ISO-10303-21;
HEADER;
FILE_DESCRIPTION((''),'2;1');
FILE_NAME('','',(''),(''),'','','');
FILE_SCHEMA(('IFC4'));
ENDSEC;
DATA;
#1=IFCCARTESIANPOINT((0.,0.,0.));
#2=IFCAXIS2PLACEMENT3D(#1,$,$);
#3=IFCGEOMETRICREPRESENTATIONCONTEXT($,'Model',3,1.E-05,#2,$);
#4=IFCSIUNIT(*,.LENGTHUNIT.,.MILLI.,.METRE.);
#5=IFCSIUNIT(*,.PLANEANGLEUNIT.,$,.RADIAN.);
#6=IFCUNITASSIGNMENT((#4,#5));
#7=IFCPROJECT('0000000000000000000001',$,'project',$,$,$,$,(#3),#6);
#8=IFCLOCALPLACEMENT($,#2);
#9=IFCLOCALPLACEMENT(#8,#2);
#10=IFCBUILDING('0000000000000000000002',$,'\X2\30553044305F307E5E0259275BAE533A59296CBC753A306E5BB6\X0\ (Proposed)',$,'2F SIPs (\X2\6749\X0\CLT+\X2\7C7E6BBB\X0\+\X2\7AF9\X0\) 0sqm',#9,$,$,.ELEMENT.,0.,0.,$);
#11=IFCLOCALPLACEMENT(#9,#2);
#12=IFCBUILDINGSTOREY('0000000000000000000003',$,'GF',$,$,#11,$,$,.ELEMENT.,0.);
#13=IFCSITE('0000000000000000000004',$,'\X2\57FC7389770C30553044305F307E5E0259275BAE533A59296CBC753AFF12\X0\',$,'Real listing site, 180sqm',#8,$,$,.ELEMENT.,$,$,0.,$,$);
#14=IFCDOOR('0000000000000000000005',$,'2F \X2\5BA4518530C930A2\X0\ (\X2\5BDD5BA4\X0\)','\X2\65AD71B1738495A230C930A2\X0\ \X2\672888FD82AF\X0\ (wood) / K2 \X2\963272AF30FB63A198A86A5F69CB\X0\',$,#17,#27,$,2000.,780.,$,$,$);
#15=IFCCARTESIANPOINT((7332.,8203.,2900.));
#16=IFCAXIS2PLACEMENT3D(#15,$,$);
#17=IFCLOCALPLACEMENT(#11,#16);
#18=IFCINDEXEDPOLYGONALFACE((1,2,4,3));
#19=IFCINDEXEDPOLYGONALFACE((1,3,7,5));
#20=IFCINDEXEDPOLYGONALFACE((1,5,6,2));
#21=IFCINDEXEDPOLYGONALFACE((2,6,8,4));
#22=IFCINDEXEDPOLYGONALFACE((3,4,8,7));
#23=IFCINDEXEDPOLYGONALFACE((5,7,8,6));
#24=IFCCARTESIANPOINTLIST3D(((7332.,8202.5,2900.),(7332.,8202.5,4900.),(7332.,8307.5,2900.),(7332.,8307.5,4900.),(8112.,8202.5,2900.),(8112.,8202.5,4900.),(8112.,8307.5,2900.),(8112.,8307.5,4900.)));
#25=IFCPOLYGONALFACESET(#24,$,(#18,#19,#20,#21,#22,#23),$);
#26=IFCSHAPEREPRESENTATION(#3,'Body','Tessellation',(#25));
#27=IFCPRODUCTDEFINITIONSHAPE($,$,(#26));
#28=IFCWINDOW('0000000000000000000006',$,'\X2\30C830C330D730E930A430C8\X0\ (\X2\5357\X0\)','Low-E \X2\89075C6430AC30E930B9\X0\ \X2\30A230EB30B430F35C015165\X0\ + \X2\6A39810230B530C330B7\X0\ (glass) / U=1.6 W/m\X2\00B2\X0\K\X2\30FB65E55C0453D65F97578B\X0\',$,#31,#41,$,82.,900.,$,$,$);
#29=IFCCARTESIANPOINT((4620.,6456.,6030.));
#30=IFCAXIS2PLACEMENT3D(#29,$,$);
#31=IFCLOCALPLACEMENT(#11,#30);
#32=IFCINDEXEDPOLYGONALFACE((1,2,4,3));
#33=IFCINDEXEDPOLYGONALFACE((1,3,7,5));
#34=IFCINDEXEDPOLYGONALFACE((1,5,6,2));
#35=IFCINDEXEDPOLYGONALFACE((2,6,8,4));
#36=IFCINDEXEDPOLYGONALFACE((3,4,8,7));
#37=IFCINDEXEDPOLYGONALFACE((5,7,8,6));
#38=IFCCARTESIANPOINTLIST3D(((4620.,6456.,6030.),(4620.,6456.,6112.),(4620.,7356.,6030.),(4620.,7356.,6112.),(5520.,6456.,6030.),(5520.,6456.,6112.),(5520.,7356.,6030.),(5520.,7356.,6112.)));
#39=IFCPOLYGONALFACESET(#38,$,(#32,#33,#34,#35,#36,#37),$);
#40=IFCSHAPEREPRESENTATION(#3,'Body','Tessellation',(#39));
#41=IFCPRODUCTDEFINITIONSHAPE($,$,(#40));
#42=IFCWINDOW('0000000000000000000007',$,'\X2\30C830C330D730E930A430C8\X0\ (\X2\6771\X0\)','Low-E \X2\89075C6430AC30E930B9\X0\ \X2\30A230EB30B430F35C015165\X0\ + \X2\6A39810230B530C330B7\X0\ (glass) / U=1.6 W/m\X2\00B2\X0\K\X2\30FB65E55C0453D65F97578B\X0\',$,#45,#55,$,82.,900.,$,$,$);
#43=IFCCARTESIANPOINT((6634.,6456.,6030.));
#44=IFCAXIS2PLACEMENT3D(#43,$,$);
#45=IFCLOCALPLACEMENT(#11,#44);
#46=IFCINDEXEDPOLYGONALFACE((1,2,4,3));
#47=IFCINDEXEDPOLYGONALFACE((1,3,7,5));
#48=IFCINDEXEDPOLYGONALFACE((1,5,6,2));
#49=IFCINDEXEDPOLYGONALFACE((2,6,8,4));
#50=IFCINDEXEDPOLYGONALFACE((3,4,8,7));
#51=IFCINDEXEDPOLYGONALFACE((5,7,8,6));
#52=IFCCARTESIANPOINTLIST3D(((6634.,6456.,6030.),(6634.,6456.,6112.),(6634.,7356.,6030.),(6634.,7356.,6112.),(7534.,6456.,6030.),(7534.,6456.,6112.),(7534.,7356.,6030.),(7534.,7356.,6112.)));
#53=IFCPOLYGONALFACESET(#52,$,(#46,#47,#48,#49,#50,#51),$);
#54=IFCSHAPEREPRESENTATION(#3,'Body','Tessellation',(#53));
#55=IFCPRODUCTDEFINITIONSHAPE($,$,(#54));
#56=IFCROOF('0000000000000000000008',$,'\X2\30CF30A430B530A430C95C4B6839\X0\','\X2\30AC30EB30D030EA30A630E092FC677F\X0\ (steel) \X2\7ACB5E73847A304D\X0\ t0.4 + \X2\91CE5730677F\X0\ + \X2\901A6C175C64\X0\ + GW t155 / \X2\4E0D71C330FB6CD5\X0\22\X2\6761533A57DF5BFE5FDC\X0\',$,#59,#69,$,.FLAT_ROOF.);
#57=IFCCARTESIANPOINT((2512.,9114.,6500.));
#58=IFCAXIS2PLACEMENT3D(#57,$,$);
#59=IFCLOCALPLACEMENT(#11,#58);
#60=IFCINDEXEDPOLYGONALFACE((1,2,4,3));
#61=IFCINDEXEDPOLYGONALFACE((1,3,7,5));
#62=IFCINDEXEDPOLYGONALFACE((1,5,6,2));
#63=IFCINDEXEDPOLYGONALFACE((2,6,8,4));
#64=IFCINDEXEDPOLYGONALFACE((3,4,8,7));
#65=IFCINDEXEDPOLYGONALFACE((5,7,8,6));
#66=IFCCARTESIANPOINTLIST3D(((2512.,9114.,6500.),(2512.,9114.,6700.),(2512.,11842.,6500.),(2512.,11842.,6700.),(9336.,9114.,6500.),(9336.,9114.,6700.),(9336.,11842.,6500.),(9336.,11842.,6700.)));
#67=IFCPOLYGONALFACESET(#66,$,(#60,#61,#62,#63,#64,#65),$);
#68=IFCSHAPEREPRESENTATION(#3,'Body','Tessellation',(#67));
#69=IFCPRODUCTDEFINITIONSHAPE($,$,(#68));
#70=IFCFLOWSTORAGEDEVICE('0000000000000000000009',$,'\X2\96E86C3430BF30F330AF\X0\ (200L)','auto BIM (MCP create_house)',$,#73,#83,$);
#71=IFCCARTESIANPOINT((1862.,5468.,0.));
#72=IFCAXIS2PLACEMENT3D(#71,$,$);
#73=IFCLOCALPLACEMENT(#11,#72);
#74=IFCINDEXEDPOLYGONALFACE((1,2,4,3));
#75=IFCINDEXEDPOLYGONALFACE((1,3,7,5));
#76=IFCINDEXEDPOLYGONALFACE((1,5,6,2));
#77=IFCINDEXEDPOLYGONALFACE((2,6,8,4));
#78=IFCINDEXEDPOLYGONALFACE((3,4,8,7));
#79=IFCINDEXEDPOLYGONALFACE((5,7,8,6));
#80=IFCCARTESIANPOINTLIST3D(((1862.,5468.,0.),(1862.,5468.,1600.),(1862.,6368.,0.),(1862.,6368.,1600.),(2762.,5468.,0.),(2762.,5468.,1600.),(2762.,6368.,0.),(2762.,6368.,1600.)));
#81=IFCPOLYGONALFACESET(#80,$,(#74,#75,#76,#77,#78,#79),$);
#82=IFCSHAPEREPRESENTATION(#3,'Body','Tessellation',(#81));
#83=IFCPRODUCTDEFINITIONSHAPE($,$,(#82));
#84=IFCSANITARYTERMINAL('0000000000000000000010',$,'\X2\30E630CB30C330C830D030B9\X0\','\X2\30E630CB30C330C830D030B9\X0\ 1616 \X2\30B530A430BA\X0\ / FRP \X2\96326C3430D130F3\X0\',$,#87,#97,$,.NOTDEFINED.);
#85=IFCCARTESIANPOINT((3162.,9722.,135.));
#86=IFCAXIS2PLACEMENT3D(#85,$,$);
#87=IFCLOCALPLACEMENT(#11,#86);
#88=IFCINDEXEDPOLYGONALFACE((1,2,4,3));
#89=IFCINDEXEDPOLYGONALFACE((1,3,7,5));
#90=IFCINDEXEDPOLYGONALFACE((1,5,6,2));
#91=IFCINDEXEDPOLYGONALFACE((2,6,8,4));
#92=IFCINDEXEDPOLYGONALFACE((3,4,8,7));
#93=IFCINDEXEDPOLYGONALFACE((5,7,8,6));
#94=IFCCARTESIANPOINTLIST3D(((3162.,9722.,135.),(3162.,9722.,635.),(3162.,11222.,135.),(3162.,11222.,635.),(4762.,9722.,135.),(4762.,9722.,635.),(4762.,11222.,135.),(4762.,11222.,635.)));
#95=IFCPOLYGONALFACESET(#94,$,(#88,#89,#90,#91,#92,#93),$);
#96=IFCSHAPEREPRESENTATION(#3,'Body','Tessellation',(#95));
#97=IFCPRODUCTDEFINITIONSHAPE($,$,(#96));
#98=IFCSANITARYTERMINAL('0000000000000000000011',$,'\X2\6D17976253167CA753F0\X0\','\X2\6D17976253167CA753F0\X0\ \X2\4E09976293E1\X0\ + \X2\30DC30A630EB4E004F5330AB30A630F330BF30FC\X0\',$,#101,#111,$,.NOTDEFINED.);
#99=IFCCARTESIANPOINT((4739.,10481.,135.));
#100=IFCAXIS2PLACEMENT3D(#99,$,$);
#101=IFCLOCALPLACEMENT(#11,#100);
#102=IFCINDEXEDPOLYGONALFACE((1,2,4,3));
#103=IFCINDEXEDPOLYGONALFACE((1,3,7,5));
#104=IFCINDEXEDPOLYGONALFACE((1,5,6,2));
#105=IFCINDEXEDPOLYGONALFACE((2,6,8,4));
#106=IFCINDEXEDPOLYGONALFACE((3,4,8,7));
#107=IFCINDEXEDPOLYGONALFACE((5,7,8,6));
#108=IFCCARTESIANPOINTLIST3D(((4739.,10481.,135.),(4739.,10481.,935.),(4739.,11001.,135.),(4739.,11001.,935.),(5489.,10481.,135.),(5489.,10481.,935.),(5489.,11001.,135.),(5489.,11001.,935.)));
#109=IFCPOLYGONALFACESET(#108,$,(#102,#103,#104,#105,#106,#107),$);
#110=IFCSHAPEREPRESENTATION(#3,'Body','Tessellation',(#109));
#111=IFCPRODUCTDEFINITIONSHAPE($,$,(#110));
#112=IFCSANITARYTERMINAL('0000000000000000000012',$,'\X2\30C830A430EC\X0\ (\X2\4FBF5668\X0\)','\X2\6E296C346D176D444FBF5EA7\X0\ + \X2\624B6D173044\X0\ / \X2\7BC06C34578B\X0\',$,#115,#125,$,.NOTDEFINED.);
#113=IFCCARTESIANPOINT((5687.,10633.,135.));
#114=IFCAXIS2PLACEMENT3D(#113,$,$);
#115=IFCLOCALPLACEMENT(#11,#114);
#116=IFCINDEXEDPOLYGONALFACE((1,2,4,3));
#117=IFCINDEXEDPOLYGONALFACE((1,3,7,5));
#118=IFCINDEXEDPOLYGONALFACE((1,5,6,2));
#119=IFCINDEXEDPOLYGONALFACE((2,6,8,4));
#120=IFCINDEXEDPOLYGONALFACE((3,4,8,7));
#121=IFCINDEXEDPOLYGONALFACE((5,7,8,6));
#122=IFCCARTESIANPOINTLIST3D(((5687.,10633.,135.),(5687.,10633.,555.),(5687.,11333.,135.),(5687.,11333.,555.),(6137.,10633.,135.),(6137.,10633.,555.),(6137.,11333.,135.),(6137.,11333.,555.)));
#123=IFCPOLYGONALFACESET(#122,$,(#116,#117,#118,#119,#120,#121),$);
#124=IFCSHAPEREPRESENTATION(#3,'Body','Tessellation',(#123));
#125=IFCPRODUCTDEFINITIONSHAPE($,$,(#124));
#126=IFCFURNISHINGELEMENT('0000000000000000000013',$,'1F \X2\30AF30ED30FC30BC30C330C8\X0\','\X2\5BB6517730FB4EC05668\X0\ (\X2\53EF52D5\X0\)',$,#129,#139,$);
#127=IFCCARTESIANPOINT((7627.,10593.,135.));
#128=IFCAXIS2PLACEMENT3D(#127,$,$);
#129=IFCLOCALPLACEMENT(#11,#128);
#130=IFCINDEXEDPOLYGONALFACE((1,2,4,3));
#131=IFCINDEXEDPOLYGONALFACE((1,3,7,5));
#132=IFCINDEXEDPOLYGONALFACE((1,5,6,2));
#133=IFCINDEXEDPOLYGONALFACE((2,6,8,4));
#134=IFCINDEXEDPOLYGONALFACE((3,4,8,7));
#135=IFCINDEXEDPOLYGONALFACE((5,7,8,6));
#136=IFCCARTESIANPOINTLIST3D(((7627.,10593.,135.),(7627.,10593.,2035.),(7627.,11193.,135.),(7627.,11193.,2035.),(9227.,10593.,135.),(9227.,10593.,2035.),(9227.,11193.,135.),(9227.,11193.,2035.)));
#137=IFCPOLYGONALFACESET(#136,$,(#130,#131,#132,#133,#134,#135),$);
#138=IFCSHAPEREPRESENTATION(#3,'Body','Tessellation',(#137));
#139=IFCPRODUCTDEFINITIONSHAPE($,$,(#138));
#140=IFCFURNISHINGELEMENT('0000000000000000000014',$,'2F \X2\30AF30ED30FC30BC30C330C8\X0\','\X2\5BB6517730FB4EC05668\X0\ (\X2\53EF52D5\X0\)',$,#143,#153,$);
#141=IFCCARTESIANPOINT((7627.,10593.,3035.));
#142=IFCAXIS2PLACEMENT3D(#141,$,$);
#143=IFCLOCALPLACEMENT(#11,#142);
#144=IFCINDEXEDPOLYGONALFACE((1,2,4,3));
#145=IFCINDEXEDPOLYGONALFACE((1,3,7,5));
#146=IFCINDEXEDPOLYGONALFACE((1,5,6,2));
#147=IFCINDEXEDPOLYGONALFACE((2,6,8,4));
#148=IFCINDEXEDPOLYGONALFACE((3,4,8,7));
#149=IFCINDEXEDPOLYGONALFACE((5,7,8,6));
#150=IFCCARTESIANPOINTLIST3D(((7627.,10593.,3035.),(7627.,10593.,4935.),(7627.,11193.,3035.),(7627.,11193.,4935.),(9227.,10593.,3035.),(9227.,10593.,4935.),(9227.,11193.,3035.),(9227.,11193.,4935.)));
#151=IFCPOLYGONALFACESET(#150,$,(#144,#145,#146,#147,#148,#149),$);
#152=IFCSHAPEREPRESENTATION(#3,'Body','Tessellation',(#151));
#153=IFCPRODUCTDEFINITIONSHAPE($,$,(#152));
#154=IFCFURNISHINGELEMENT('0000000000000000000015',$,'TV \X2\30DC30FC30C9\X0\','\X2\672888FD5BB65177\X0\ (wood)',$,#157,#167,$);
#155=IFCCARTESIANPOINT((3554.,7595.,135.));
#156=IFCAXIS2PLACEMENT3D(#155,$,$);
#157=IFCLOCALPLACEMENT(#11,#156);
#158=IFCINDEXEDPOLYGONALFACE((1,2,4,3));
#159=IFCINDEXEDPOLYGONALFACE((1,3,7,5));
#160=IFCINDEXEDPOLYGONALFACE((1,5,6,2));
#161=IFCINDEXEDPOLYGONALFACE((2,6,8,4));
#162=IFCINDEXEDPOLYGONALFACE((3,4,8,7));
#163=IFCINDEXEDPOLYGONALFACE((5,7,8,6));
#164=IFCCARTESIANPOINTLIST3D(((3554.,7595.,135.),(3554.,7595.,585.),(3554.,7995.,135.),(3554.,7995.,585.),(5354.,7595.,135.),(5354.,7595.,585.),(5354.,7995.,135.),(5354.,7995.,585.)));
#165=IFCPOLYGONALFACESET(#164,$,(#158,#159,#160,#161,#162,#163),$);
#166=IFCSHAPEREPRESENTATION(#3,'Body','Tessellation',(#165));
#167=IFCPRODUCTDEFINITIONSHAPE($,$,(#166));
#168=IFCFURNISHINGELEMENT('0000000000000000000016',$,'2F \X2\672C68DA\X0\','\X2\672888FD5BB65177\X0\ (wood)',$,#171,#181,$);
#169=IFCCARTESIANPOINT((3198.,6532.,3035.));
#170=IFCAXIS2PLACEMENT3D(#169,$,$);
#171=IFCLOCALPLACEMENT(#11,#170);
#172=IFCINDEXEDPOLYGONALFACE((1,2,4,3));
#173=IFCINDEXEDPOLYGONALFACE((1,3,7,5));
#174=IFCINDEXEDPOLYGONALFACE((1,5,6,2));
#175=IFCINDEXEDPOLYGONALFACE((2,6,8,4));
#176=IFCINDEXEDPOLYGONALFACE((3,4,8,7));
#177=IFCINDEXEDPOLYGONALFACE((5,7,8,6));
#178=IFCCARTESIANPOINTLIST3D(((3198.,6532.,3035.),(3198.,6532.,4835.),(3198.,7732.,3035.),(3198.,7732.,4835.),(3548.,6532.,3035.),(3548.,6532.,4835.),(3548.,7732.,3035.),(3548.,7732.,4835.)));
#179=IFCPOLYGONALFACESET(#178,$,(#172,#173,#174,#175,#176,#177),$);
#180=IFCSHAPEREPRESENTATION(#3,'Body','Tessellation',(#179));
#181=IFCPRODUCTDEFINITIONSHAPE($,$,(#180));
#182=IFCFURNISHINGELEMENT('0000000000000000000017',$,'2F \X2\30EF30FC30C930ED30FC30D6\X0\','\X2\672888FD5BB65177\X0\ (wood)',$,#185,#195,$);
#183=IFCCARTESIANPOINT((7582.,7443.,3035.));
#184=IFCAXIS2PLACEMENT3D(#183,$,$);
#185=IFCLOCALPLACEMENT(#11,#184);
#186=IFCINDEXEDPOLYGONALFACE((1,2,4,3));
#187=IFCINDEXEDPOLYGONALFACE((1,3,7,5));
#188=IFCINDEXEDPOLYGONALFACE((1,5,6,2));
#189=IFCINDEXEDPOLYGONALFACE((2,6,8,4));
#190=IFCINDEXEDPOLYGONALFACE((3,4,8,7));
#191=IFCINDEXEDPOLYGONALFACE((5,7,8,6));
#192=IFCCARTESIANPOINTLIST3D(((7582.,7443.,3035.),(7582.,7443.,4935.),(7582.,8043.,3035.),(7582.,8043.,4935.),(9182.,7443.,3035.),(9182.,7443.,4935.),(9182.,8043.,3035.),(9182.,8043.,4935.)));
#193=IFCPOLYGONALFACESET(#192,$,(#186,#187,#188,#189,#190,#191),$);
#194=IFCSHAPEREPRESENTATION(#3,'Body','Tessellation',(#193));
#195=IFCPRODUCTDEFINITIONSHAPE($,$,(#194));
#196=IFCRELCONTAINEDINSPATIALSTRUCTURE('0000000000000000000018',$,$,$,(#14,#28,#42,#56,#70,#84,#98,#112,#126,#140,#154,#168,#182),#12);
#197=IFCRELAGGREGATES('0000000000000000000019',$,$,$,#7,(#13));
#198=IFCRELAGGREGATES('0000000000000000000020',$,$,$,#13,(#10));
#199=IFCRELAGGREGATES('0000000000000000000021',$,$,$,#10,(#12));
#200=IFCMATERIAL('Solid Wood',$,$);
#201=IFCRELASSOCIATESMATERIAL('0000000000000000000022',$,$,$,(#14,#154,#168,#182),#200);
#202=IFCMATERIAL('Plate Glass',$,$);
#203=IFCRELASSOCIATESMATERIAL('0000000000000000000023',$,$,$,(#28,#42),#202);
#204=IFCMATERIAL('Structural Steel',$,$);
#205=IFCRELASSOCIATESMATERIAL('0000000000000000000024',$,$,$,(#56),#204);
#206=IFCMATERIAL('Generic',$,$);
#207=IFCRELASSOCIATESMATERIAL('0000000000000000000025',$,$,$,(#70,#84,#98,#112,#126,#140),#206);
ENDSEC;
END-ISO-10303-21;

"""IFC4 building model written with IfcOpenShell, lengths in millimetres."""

from ifc_helpers import new_model, si_unit, frame, frame_2d, origin, place, context, project, spatial, rectangle, extrude, material, element, save


model = new_model("IFC4")

# Units and contexts
model_context = context("Model", 3, precision=1e-05, world=origin())
ifc_project = project(units=[si_unit("LENGTHUNIT", "METRE", prefix="MILLI"), si_unit("PLANEANGLEUNIT", "RADIAN")], contexts=[model_context])

# Site, building, storey
site_placement = place(None, origin())
site = spatial("IfcSite", under=ifc_project, at=site_placement, Name="埼玉県さいたま市大宮区天沼町２", ObjectType="Real listing site, 180sqm", CompositionType="ELEMENT", RefElevation=0.0)
building_placement = place(site_placement, origin())
building = spatial("IfcBuilding", under=site, at=building_placement, Name="さいたま市大宮区天沼町の家 (Proposed)", ObjectType="2F SIPs (杉CLT+籾殻+竹) 0sqm", CompositionType="ELEMENT", ElevationOfRefHeight=0.0, ElevationOfTerrain=0.0)
storey_placement = place(building_placement, origin())
storey = spatial("IfcBuildingStorey", under=building, at=storey_placement, Name="GF", CompositionType="ELEMENT", Elevation=0.0)

# Shared definitions
ifc_material_1 = material(Name="Solid Wood")
ifc_material_2 = material(Name="Plate Glass")

# Door
door_1_placement = place(storey_placement, frame((7332.0, 8203.0, 2900.0)))
element("IfcDoor", 1, at=door_1_placement, inside=storey, material=ifc_material_1, Name="2F 室内ドア (寝室)", Description="断熱玄関ドア 木製芯 (wood) / K2 防犯・採風機構", OverallHeight=2000.0, OverallWidth=780.0, context=model_context, shape_type="SweptSolid", body=[
    extrude(rectangle(XDim=780.0, YDim=105.0, at=frame_2d((390.0, 52.0))), frame((7332.0, 8203.0, 2900.0)), (0.0, 0.0, 1.0), 2000.0),
])

# Windows
window_1_placement = place(storey_placement, frame((4620.0, 6456.0, 6030.0)))
element("IfcWindow", 2, at=window_1_placement, inside=storey, material=ifc_material_2, Name="トップライト (南)", Description="Low-E 複層ガラス アルゴン封入 + 樹脂サッシ (glass) / U=1.6 W/m²K・日射取得型", OverallHeight=82.0, OverallWidth=900.0, context=model_context, shape_type="SweptSolid", body=[
    extrude(rectangle(XDim=900.0, YDim=900.0, at=frame_2d((450.0, 450.0))), frame((4620.0, 6456.0, 6030.0)), (0.0, 0.0, 1.0), 82.0),
])
window_2_placement = place(storey_placement, frame((6634.0, 6456.0, 6030.0)))
element("IfcWindow", 3, at=window_2_placement, inside=storey, material=ifc_material_2, Name="トップライト (東)", Description="Low-E 複層ガラス アルゴン封入 + 樹脂サッシ (glass) / U=1.6 W/m²K・日射取得型", OverallHeight=82.0, OverallWidth=900.0, context=model_context, shape_type="SweptSolid", body=[
    extrude(rectangle(XDim=900.0, YDim=900.0, at=frame_2d((450.0, 450.0))), frame((6634.0, 6456.0, 6030.0)), (0.0, 0.0, 1.0), 82.0),
])

# Roof
ifc_material_3 = material(Name="Structural Steel")
roof_placement = place(storey_placement, frame((2512.0, 9114.0, 6500.0)))
element("IfcRoof", 4, at=roof_placement, inside=storey, material=ifc_material_3, Name="ハイサイド屋根", Description="ガルバリウム鋼板 (steel) 立平葺き t0.4 + 野地板 + 通気層 + GW t155 / 不燃・法22条区域対応", PredefinedType="FLAT_ROOF", context=model_context, shape_type="SweptSolid", body=[
    extrude(rectangle(XDim=6824.0, YDim=2728.0, at=frame_2d((3412.0, 1364.0))), frame((2512.0, 9114.0, 6500.0)), (0.0, 0.0, 1.0), 200.0),
])

# Flow storage device
ifc_material_4 = material(Name="Generic")
flow_storage_device_placement = place(storey_placement, frame((1862.0, 5468.0, 0.0)))
element("IfcFlowStorageDevice", 5, at=flow_storage_device_placement, inside=storey, material=ifc_material_4, Name="雨水タンク (200L)", Description="auto BIM (MCP create_house)", context=model_context, shape_type="SweptSolid", body=[
    extrude(rectangle(XDim=900.0, YDim=900.0, at=frame_2d((450.0, 450.0))), frame((1862.0, 5468.0, 0.0)), (0.0, 0.0, 1.0), 1600.0),
])

# Sanitary terminals
sanitary_terminal_1_placement = place(storey_placement, frame((3162.0, 9722.0, 135.0)))
element("IfcSanitaryTerminal", 6, at=sanitary_terminal_1_placement, inside=storey, material=ifc_material_4, Name="ユニットバス", Description="ユニットバス 1616 サイズ / FRP 防水パン", PredefinedType="NOTDEFINED", context=model_context, shape_type="SweptSolid", body=[
    extrude(rectangle(XDim=1600.0, YDim=1500.0, at=frame_2d((800.0, 750.0))), frame((3162.0, 9722.0, 135.0)), (0.0, 0.0, 1.0), 500.0),
])
sanitary_terminal_2_placement = place(storey_placement, frame((4739.0, 10481.0, 135.0)))
element("IfcSanitaryTerminal", 7, at=sanitary_terminal_2_placement, inside=storey, material=ifc_material_4, Name="洗面化粧台", Description="洗面化粧台 三面鏡 + ボウル一体カウンター", PredefinedType="NOTDEFINED", context=model_context, shape_type="SweptSolid", body=[
    extrude(rectangle(XDim=750.0, YDim=520.0, at=frame_2d((375.0, 260.0))), frame((4739.0, 10481.0, 135.0)), (0.0, 0.0, 1.0), 800.0),
])
sanitary_terminal_3_placement = place(storey_placement, frame((5687.0, 10633.0, 135.0)))
element("IfcSanitaryTerminal", 8, at=sanitary_terminal_3_placement, inside=storey, material=ifc_material_4, Name="トイレ (便器)", Description="温水洗浄便座 + 手洗い / 節水型", PredefinedType="NOTDEFINED", context=model_context, shape_type="SweptSolid", body=[
    extrude(rectangle(XDim=450.0, YDim=700.0, at=frame_2d((225.0, 350.0))), frame((5687.0, 10633.0, 135.0)), (0.0, 0.0, 1.0), 420.0),
])

# Furnishing elements
furnishing_1_placement = place(storey_placement, frame((7627.0, 10593.0, 135.0)))
element("IfcFurnishingElement", 9, at=furnishing_1_placement, inside=storey, material=ifc_material_4, Name="1F クローゼット", Description="家具・什器 (可動)", context=model_context, shape_type="SweptSolid", body=[
    extrude(rectangle(XDim=1600.0, YDim=600.0, at=frame_2d((800.0, 300.0))), frame((7627.0, 10593.0, 135.0)), (0.0, 0.0, 1.0), 1900.0),
])
furnishing_2_placement = place(storey_placement, frame((7627.0, 10593.0, 3035.0)))
element("IfcFurnishingElement", 10, at=furnishing_2_placement, inside=storey, material=ifc_material_4, Name="2F クローゼット", Description="家具・什器 (可動)", context=model_context, shape_type="SweptSolid", body=[
    extrude(rectangle(XDim=1600.0, YDim=600.0, at=frame_2d((800.0, 300.0))), frame((7627.0, 10593.0, 3035.0)), (0.0, 0.0, 1.0), 1900.0),
])
furnishing_3_placement = place(storey_placement, frame((3554.0, 7595.0, 135.0)))
element("IfcFurnishingElement", 11, at=furnishing_3_placement, inside=storey, material=ifc_material_1, Name="TV ボード", Description="木製家具 (wood)", context=model_context, shape_type="SweptSolid", body=[
    extrude(rectangle(XDim=1800.0, YDim=400.0, at=frame_2d((900.0, 200.0))), frame((3554.0, 7595.0, 135.0)), (0.0, 0.0, 1.0), 450.0),
])
furnishing_4_placement = place(storey_placement, frame((3198.0, 6532.0, 3035.0)))
element("IfcFurnishingElement", 12, at=furnishing_4_placement, inside=storey, material=ifc_material_1, Name="2F 本棚", Description="木製家具 (wood)", context=model_context, shape_type="SweptSolid", body=[
    extrude(rectangle(XDim=350.0, YDim=1200.0, at=frame_2d((175.0, 600.0))), frame((3198.0, 6532.0, 3035.0)), (0.0, 0.0, 1.0), 1800.0),
])
furnishing_5_placement = place(storey_placement, frame((7582.0, 7443.0, 3035.0)))
element("IfcFurnishingElement", 13, at=furnishing_5_placement, inside=storey, material=ifc_material_1, Name="2F ワードローブ", Description="木製家具 (wood)", context=model_context, shape_type="SweptSolid", body=[
    extrude(rectangle(XDim=1600.0, YDim=600.0, at=frame_2d((800.0, 300.0))), frame((7582.0, 7443.0, 3035.0)), (0.0, 0.0, 1.0), 1900.0),
])

save(model, "model.ifc")
